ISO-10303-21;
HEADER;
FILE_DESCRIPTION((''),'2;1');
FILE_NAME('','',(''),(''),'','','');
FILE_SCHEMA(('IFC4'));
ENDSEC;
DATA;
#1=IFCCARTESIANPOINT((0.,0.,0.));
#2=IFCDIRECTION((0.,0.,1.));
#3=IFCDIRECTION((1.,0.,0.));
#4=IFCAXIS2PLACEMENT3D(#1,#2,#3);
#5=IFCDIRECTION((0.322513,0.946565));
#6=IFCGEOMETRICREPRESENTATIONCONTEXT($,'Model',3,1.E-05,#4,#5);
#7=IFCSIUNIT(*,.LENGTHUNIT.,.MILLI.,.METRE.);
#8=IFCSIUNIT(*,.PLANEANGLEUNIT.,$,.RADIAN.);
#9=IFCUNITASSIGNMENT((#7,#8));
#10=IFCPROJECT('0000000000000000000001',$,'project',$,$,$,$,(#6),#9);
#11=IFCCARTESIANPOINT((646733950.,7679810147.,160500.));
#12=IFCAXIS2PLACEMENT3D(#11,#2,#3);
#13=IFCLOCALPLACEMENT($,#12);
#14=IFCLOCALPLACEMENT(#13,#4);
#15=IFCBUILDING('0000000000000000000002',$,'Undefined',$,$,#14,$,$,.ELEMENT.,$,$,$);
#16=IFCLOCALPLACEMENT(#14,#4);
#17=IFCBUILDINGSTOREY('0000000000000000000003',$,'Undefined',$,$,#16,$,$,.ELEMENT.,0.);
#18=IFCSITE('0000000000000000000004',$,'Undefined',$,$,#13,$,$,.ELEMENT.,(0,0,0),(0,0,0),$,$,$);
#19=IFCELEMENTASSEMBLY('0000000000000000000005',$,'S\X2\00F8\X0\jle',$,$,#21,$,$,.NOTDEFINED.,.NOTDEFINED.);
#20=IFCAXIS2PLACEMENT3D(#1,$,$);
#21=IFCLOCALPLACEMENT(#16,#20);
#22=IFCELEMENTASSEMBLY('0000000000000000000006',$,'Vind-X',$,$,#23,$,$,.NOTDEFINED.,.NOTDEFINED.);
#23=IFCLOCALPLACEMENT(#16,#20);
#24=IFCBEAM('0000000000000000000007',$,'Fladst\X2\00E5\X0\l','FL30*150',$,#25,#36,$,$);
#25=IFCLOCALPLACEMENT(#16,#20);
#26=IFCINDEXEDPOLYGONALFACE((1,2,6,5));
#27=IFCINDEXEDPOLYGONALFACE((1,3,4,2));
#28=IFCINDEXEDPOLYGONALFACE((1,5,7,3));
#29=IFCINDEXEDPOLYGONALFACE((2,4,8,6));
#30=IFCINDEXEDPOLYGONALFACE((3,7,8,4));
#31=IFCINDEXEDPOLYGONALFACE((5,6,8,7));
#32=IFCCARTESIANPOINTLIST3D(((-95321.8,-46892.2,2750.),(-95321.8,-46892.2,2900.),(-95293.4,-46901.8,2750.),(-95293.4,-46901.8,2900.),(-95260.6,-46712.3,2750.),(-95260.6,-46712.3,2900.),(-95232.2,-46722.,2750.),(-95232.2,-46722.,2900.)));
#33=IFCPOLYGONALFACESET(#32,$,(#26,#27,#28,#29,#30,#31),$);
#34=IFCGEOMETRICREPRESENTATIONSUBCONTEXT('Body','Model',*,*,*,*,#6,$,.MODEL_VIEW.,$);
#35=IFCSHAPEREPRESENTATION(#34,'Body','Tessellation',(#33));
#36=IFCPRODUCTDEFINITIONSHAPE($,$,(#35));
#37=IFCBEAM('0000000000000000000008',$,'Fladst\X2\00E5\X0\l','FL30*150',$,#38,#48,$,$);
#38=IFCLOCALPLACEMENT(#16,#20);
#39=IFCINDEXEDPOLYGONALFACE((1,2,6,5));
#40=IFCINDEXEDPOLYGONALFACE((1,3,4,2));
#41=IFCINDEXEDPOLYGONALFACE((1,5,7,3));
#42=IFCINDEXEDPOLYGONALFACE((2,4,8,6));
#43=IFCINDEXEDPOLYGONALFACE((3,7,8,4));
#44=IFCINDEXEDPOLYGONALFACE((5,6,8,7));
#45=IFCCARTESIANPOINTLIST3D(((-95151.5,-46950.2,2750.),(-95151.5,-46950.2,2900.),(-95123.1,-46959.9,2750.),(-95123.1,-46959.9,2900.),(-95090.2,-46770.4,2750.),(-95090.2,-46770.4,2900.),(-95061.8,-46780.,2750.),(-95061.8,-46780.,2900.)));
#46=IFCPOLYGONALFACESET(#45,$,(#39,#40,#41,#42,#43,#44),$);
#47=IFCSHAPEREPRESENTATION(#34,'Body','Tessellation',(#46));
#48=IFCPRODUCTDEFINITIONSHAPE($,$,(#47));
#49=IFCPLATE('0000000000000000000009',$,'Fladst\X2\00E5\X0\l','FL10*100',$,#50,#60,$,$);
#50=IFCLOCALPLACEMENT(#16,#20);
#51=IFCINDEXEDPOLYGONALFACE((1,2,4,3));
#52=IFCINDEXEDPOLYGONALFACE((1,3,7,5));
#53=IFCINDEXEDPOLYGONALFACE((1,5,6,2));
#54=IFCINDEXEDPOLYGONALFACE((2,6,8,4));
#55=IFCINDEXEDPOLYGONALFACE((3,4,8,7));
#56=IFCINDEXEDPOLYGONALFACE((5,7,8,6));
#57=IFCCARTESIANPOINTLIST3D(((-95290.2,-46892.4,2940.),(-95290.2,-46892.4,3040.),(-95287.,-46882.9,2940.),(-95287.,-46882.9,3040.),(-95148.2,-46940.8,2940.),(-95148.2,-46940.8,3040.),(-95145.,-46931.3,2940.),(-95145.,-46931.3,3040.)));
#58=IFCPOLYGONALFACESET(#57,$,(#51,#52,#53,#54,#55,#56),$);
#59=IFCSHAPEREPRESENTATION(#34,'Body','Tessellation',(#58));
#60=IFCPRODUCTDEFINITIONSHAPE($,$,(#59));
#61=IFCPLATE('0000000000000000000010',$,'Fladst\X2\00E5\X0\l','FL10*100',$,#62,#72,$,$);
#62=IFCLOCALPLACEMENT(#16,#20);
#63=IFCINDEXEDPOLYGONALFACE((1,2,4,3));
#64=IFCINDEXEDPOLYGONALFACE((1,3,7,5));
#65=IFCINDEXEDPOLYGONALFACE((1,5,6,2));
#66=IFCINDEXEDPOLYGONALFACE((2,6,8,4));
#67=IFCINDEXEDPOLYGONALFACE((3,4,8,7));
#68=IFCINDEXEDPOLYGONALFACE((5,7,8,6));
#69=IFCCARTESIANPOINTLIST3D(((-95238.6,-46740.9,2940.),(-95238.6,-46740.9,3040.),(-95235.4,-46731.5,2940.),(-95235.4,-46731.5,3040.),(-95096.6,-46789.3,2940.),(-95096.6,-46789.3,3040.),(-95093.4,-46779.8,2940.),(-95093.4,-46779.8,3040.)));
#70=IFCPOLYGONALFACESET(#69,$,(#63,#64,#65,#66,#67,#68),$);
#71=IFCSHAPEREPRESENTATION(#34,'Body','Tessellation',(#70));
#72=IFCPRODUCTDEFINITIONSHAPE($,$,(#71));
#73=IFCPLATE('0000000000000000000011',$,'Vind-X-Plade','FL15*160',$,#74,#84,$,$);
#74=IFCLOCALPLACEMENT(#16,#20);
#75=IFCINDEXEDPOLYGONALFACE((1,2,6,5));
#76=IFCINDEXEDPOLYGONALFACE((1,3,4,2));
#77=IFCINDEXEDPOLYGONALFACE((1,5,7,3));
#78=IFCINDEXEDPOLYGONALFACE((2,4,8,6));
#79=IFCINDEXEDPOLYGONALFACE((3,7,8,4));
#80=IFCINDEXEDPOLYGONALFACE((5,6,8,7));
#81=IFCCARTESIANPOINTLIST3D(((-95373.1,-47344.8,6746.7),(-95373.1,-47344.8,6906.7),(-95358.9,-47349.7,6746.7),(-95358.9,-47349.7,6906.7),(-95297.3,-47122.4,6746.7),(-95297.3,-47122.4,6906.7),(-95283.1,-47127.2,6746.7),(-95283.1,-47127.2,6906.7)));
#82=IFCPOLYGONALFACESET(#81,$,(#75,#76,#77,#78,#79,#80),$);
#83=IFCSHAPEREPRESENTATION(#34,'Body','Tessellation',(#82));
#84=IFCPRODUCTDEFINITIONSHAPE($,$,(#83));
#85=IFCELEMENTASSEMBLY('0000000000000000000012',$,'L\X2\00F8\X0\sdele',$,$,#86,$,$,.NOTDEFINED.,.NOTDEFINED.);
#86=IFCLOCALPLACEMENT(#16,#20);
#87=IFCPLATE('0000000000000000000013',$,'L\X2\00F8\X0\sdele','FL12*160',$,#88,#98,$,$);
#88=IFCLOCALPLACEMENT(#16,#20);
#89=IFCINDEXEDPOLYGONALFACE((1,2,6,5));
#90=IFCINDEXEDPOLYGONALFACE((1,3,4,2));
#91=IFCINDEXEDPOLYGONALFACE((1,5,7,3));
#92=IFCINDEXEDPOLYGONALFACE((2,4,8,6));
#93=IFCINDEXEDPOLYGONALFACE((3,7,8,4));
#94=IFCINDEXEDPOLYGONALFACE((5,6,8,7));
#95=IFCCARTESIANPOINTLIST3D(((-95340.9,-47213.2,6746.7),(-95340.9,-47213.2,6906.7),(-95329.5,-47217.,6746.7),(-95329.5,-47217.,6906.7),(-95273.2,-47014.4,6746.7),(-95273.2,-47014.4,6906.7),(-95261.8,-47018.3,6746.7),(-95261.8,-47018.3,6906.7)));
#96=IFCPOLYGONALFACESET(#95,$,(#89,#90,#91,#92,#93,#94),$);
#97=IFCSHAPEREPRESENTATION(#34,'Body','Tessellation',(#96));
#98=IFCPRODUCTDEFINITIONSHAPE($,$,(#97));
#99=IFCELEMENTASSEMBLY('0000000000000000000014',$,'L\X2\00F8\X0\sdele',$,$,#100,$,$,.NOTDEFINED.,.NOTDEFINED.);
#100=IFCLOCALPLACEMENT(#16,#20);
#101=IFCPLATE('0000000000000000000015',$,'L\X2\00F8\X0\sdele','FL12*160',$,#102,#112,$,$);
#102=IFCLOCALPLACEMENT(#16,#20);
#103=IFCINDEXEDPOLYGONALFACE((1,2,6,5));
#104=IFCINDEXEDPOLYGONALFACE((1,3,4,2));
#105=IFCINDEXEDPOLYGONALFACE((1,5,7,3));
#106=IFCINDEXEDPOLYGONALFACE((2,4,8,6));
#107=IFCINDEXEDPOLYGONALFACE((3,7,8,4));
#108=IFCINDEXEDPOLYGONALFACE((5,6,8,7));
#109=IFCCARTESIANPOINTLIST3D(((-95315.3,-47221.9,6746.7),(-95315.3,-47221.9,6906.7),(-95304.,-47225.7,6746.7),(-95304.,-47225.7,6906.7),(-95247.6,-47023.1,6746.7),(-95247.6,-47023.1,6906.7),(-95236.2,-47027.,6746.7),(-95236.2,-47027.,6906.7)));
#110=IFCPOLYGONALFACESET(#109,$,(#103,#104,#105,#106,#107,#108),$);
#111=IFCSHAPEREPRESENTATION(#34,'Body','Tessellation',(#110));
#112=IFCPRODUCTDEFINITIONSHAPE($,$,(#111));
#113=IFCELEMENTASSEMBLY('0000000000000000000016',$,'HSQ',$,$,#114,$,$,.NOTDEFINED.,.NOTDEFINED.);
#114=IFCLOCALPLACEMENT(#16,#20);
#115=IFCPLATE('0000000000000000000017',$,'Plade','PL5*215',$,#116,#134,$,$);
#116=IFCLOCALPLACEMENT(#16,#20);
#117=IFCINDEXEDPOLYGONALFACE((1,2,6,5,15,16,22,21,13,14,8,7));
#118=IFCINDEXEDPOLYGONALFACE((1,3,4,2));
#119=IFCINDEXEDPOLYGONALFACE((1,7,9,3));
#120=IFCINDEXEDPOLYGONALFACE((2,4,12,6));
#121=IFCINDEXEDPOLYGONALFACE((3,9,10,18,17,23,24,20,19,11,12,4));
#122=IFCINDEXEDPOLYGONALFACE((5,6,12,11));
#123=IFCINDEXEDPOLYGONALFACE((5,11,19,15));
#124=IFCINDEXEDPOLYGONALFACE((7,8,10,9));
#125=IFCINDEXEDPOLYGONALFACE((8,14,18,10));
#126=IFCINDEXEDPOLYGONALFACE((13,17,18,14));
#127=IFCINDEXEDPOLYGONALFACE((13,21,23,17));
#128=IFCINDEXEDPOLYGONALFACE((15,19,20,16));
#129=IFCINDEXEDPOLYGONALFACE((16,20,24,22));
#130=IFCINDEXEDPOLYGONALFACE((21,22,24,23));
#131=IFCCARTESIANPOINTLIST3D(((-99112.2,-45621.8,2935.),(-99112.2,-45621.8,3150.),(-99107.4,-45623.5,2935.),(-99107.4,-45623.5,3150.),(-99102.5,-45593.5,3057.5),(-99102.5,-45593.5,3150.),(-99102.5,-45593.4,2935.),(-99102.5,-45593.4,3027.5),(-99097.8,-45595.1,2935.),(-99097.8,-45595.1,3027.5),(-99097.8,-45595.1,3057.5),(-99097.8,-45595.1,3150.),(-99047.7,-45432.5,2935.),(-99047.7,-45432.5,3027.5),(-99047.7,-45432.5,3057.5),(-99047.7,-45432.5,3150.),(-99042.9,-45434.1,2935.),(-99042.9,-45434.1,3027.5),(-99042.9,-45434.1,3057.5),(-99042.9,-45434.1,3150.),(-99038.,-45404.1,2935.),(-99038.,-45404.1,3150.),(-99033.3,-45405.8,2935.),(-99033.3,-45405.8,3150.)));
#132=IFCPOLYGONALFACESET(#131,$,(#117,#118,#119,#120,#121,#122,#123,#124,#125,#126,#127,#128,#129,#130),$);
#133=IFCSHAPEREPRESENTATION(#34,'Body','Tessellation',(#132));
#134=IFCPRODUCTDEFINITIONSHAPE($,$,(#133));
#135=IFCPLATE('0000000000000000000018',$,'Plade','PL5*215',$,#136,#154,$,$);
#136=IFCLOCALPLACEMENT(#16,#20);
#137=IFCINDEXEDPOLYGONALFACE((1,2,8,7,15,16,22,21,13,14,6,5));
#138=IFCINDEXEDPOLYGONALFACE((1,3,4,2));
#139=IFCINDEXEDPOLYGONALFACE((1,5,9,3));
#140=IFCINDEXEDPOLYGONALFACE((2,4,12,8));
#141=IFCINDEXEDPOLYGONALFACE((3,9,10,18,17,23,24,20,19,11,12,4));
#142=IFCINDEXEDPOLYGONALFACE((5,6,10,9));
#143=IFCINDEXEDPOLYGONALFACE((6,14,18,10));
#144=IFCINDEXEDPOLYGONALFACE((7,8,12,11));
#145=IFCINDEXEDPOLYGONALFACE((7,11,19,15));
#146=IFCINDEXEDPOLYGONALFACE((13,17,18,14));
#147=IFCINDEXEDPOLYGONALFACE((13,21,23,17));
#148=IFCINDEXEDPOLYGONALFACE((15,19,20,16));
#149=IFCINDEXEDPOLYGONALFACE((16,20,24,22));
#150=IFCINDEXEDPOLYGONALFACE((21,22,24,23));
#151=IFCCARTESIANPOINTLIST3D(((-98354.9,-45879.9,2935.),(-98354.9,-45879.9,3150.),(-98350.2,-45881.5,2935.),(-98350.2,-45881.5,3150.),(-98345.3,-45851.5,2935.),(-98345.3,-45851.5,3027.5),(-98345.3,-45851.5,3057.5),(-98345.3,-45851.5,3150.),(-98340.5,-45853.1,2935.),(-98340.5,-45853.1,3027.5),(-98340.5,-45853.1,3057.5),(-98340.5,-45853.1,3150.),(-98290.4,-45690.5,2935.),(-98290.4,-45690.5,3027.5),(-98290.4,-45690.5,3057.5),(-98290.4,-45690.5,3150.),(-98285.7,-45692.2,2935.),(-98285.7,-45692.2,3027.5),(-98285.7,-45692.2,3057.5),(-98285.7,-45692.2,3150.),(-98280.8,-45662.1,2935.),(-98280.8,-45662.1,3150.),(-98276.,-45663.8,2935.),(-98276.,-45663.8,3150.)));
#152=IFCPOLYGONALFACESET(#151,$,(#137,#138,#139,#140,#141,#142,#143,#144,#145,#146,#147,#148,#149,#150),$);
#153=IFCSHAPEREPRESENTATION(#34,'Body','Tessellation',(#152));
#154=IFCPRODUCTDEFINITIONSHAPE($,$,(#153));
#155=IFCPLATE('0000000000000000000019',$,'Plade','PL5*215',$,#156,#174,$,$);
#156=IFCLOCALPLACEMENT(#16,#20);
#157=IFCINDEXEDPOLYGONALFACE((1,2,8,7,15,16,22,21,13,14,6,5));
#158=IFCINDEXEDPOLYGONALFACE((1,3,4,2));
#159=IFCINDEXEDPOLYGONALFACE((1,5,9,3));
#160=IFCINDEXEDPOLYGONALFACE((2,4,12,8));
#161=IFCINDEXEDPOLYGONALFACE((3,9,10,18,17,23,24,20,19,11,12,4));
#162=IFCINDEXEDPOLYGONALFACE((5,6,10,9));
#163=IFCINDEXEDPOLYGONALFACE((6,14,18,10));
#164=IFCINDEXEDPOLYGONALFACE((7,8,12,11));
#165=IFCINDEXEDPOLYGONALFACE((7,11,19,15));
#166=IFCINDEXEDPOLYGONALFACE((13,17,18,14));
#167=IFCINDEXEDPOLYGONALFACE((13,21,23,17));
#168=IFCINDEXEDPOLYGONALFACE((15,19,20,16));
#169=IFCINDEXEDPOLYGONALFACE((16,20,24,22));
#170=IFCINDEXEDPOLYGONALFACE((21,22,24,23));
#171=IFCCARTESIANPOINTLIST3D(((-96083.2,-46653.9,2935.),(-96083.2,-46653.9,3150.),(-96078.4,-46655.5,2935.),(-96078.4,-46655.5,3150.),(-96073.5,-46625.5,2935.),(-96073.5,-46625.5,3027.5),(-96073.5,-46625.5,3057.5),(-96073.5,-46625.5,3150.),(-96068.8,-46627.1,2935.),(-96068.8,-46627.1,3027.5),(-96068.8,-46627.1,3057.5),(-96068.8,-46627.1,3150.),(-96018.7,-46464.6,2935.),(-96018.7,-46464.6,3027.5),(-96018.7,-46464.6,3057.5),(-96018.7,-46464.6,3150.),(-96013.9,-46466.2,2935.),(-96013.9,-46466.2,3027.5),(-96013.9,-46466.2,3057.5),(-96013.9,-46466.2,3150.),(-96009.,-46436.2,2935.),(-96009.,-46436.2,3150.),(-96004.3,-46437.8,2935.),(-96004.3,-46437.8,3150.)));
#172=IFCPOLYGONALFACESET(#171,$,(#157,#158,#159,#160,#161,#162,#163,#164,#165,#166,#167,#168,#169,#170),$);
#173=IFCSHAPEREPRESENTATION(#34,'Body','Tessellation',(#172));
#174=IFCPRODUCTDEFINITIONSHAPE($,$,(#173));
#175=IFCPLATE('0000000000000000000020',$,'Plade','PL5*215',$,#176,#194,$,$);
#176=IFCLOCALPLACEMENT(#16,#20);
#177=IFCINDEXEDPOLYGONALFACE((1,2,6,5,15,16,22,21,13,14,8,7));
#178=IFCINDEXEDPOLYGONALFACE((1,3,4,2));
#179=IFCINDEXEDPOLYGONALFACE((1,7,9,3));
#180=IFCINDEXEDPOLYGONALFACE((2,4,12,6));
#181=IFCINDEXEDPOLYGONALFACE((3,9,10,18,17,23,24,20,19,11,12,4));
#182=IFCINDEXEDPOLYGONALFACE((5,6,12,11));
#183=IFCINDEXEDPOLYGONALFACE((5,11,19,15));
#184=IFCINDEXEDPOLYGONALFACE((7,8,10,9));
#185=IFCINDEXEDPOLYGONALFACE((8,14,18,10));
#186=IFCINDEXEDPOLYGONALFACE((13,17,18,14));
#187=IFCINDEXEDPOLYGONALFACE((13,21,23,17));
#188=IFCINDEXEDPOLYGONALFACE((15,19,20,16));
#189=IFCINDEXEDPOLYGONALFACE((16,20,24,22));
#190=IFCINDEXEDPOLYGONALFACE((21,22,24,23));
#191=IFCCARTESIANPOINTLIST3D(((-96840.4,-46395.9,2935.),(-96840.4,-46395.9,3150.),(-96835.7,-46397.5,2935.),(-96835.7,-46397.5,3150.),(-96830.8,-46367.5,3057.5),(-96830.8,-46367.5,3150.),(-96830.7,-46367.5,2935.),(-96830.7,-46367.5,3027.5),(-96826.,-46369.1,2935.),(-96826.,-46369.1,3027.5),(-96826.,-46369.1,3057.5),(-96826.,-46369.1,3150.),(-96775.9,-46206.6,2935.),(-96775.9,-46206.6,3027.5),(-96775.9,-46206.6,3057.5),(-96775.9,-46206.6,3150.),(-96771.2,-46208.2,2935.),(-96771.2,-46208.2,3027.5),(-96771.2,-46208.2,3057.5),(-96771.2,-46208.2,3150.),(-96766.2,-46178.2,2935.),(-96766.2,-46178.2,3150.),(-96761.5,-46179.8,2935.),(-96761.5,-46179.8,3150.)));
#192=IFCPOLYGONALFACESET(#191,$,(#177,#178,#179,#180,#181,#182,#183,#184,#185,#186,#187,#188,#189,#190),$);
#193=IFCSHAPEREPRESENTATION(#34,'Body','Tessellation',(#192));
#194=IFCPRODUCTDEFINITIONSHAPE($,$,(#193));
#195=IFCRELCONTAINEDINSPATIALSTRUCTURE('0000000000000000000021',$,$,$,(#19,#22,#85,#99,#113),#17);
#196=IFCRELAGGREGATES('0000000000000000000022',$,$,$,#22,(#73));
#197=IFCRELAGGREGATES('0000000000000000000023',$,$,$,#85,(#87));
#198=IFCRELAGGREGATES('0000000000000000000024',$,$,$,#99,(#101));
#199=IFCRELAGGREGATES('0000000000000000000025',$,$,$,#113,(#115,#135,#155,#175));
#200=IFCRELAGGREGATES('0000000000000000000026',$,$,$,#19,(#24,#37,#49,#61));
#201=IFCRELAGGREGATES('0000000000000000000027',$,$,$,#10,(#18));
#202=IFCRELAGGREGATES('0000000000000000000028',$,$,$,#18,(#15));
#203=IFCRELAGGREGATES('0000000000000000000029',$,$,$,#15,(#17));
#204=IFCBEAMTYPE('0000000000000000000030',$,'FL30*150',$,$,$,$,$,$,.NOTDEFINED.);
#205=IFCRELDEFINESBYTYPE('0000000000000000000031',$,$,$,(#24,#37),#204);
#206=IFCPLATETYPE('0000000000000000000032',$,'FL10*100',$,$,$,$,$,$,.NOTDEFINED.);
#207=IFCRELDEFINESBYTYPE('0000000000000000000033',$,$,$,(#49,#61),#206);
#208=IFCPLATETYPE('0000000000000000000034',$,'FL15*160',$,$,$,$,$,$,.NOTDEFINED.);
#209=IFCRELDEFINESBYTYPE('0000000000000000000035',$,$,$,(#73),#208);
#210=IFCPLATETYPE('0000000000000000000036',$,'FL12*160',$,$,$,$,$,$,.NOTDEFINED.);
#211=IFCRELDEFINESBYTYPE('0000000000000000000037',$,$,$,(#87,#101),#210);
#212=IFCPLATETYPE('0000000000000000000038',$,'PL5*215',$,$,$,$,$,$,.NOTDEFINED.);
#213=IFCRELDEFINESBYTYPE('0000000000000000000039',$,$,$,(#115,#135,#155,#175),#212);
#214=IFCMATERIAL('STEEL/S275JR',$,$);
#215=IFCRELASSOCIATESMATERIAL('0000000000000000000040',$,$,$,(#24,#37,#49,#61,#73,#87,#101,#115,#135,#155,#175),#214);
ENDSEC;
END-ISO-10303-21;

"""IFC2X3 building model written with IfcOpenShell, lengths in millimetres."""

from ifc_helpers import new_model, si_unit, direction, frame, origin_with_axes, origin_2d_with_axis, place, context, subcontext, project, spatial, polyline, rectangle, outline, extrude, material, type_object, element, aggregate, save


model = new_model("IFC2X3")

# Units and contexts
model_context = context("Model", 3, precision=1e-05, world=origin_with_axes(), true_north=direction((0.322513, 0.946565)))
body_context = subcontext(model_context, "Body", "Model", "MODEL_VIEW")
ifc_project = project(units=[si_unit("LENGTHUNIT", "METRE", prefix="MILLI"), si_unit("PLANEANGLEUNIT", "RADIAN")], contexts=[model_context])

# Site, building, storey
site_placement = place(None, frame((646733950.0, 7679810147.0, 160500.0), z_axis=(0.0, 0.0, 1.0), x_axis=(1.0, 0.0, 0.0)))
site = spatial("IfcSite", under=ifc_project, at=site_placement, Name="Undefined", CompositionType="ELEMENT", RefLatitude=(0, 0, 0), RefLongitude=(0, 0, 0))
building_placement = place(site_placement, origin_with_axes())
building = spatial("IfcBuilding", under=site, at=building_placement, Name="Undefined", CompositionType="ELEMENT")
storey_placement = place(building_placement, origin_with_axes())
storey = spatial("IfcBuildingStorey", under=building, at=storey_placement, Name="Undefined", CompositionType="ELEMENT", Elevation=0.0)

# Element assembly
assembly_1_placement = place(storey_placement, origin_with_axes())
assembly_1 = element("IfcElementAssembly", 1, at=assembly_1_placement, inside=storey, Name="Søjle", AssemblyPlace="NOTDEFINED", PredefinedType="NOTDEFINED")

# Element assembly
assembly_2_placement = place(storey_placement, origin_with_axes())
assembly_2 = element("IfcElementAssembly", 2, at=assembly_2_placement, inside=storey, Name="Vind-X", AssemblyPlace="NOTDEFINED", PredefinedType="NOTDEFINED")

# Beams
ifc_material_1 = material(Name="STEEL/S275JR")
beam_type_1 = type_object("IfcBeamType", Name="FL30*150", PredefinedType="NOTDEFINED")
beam_1_placement = place(assembly_1_placement, frame((-95277.0, -46807.1, 2900.0), z_axis=(-0.322513, -0.946565, 0.0), x_axis=(0.0, 0.0, -1.0)))
beam_1 = element("IfcBeam", 3, at=beam_1_placement, type_object=beam_type_1, material=ifc_material_1, Name="Fladstål", Description="FL30*150", context=body_context, shape_type="SweptSolid", body=[
    extrude(rectangle(XDim=30.0, YDim=190.0, at=origin_2d_with_axis()), frame((150.0, 0.0, 0.0), z_axis=(-1.0, 0.0, 0.0), x_axis=(0.0, -1.0, 0.0)), (0.0, 0.0, 1.0), 150.0),
])
beam_2_placement = place(assembly_1_placement, frame((-95106.6, -46865.1, 2900.0), z_axis=(-0.322513, -0.946565, 0.0), x_axis=(0.0, 0.0, -1.0)))
beam_2 = element("IfcBeam", 4, at=beam_2_placement, type_object=beam_type_1, material=ifc_material_1, Name="Fladstål", Description="FL30*150", context=body_context, shape_type="SweptSolid", body=[
    extrude(rectangle(XDim=30.0, YDim=190.0, at=origin_2d_with_axis()), frame((150.0, 0.0, 0.0), z_axis=(-1.0, 0.0, 0.0), x_axis=(0.0, -1.0, 0.0)), (0.0, 0.0, 1.0), 150.0),
])

# Plates
plate_type_1 = type_object("IfcPlateType", Name="FL10*100", PredefinedType="NOTDEFINED")
plate_1_placement = place(assembly_1_placement, frame((-95146.6, -46936.0, 3040.0), z_axis=(-0.322513, -0.946565, 0.0), x_axis=(-0.946565, 0.322513, 0.0)))
plate_1 = element("IfcPlate", 5, at=plate_1_placement, type_object=plate_type_1, material=ifc_material_1, Name="Fladstål", Description="FL10*100", context=body_context, shape_type="SweptSolid", body=[
    extrude(outline(polyline([(0.0, 0.0), (150.0, 0.0), (150.0, 100.0), (0.0, 100.0), (0.0, 0.0)])), frame((0.0, 0.0, -5.0), z_axis=(0.0, 0.0, 1.0), x_axis=(1.0, 0.0, 0.0)), (0.0, 0.0, 1.0), 10.0),
])
plate_2_placement = place(assembly_1_placement, frame((-95095.0, -46784.6, 3040.0), z_axis=(-0.322513, -0.946565, 0.0), x_axis=(-0.946565, 0.322513, 0.0)))
plate_2 = element("IfcPlate", 6, at=plate_2_placement, type_object=plate_type_1, material=ifc_material_1, Name="Fladstål", Description="FL10*100", context=body_context, shape_type="SweptSolid", body=[
    extrude(outline(polyline([(0.0, 0.0), (150.0, 0.0), (150.0, 100.0), (0.0, 100.0), (0.0, 0.0)])), frame((0.0, 0.0, -5.0), z_axis=(0.0, 0.0, 1.0), x_axis=(1.0, 0.0, 0.0)), (0.0, 0.0, 1.0), 10.0),
])
plate_type_2 = type_object("IfcPlateType", Name="FL15*160", PredefinedType="NOTDEFINED")
plate_3_placement = place(assembly_2_placement, frame((-95290.2, -47124.8, 6826.7), z_axis=(0.946565, -0.322513, 0.0), x_axis=(-0.322513, -0.946565, 0.0)))
plate_3 = element("IfcPlate", 7, at=plate_3_placement, type_object=plate_type_2, material=ifc_material_1, Name="Vind-X-Plade", Description="FL15*160", context=body_context, shape_type="SweptSolid", body=[
    extrude(outline(polyline([(0.0, -80.0), (0.0, 80.0), (235.0, 80.0), (235.0, -80.0), (0.0, -80.0)])), frame((0.0, 0.0, -7.5), z_axis=(0.0, 0.0, 1.0), x_axis=(1.0, 0.0, 0.0)), (0.0, 0.0, 1.0), 15.0),
])
aggregate(assembly_2, [plate_3])

# Element assemblies, plates
assembly_3_placement = place(storey_placement, origin_with_axes())
assembly_3 = element("IfcElementAssembly", 8, at=assembly_3_placement, inside=storey, Name="Løsdele", AssemblyPlace="NOTDEFINED", PredefinedType="NOTDEFINED")
plate_type_3 = type_object("IfcPlateType", Name="FL12*160", PredefinedType="NOTDEFINED")
plate_4_placement = place(assembly_3_placement, frame((-95267.5, -47016.3, 6826.7), z_axis=(-0.946565, 0.322513, 0.0), x_axis=(-0.322513, -0.946565, 0.0)))
plate_4 = element("IfcPlate", 9, at=plate_4_placement, type_object=plate_type_3, material=ifc_material_1, Name="Løsdele", Description="FL12*160", context=body_context, shape_type="SweptSolid", body=[
    extrude(outline(polyline([(0.0, -80.0), (0.0, 80.0), (210.0, 80.0), (210.0, -80.0), (0.0, -80.0)])), frame((0.0, 0.0, -6.0), z_axis=(0.0, 0.0, 1.0), x_axis=(1.0, 0.0, 0.0)), (0.0, 0.0, 1.0), 12.0),
])
aggregate(assembly_3, [plate_4])
assembly_4_placement = place(storey_placement, origin_with_axes())
assembly_4 = element("IfcElementAssembly", 10, at=assembly_4_placement, inside=storey, Name="Løsdele", AssemblyPlace="NOTDEFINED", PredefinedType="NOTDEFINED")
plate_5_placement = place(assembly_4_placement, frame((-95241.9, -47025.0, 6826.7), z_axis=(-0.946565, 0.322513, 0.0), x_axis=(-0.322513, -0.946565, 0.0)))
plate_5 = element("IfcPlate", 11, at=plate_5_placement, type_object=plate_type_3, material=ifc_material_1, Name="Løsdele", Description="FL12*160", context=body_context, shape_type="SweptSolid", body=[
    extrude(outline(polyline([(0.0, -80.0), (0.0, 80.0), (210.0, 80.0), (210.0, -80.0), (0.0, -80.0)])), frame((0.0, 0.0, -6.0), z_axis=(0.0, 0.0, 1.0), x_axis=(1.0, 0.0, 0.0)), (0.0, 0.0, 1.0), 12.0),
])

# Element assembly, plates
assembly_5_placement = place(storey_placement, origin_with_axes())
assembly_5 = element("IfcElementAssembly", 12, at=assembly_5_placement, inside=storey, Name="HSQ", AssemblyPlace="NOTDEFINED", PredefinedType="NOTDEFINED")
plate_type_4 = type_object("IfcPlateType", Name="PL5*215", PredefinedType="NOTDEFINED")
plate_6_placement = place(assembly_5_placement, frame((-99109.8, -45622.7, 3150.0), z_axis=(0.946565, -0.322513, 0.0), x_axis=(0.0, 0.0, -1.0)))
plate_6 = element("IfcPlate", 13, at=plate_6_placement, type_object=plate_type_4, material=ifc_material_1, Name="Plade", Description="PL5*215", context=body_context, shape_type="SweptSolid", body=[
    extrude(outline(polyline([(0.0, 0.0), (215.0, 0.0), (215.0, 30.0), (122.5, 30.0), (122.5, 200.0), (215.0, 200.0), (215.0, 230.0), (0.0, 230.0), (0.0, 200.0), (92.5, 200.0), (92.5, 30.0), (0.0, 30.0), (0.0, 0.0)])), frame((0.0, 0.0, -2.5), z_axis=(0.0, 0.0, 1.0), x_axis=(1.0, 0.0, 0.0)), (0.0, 0.0, 1.0), 5.0),
])
plate_7_placement = place(assembly_5_placement, frame((-98352.6, -45880.7, 3150.0), z_axis=(0.946565, -0.322513, 0.0), x_axis=(0.0, 0.0, -1.0)))
plate_7 = element("IfcPlate", 14, at=plate_7_placement, type_object=plate_type_4, material=ifc_material_1, Name="Plade", Description="PL5*215", context=body_context, shape_type="SweptSolid", body=[
    extrude(outline(polyline([(0.0, 0.0), (215.0, 0.0), (215.0, 30.0), (122.5, 30.0), (122.5, 200.0), (215.0, 200.0), (215.0, 230.0), (0.0, 230.0), (0.0, 200.0), (92.5, 200.0), (92.5, 30.0), (0.0, 30.0), (0.0, 0.0)])), frame((0.0, 0.0, -2.5), z_axis=(0.0, 0.0, 1.0), x_axis=(1.0, 0.0, 0.0)), (0.0, 0.0, 1.0), 5.0),
])
plate_8_placement = place(assembly_5_placement, frame((-96080.8, -46654.7, 3150.0), z_axis=(0.946565, -0.322513, 0.0), x_axis=(0.0, 0.0, -1.0)))
plate_8 = element("IfcPlate", 15, at=plate_8_placement, type_object=plate_type_4, material=ifc_material_1, Name="Plade", Description="PL5*215", context=body_context, shape_type="SweptSolid", body=[
    extrude(outline(polyline([(0.0, 0.0), (215.0, 0.0), (215.0, 30.0), (122.5, 30.0), (122.5, 200.0), (215.0, 200.0), (215.0, 230.0), (0.0, 230.0), (0.0, 200.0), (92.5, 200.0), (92.5, 30.0), (0.0, 30.0), (0.0, 0.0)])), frame((0.0, 0.0, -2.5), z_axis=(0.0, 0.0, 1.0), x_axis=(1.0, 0.0, 0.0)), (0.0, 0.0, 1.0), 5.0),
])
plate_9_placement = place(assembly_5_placement, frame((-96838.1, -46396.7, 3150.0), z_axis=(0.946565, -0.322513, 0.0), x_axis=(0.0, 0.0, -1.0)))
plate_9 = element("IfcPlate", 16, at=plate_9_placement, type_object=plate_type_4, material=ifc_material_1, Name="Plade", Description="PL5*215", context=body_context, shape_type="SweptSolid", body=[
    extrude(outline(polyline([(0.0, 0.0), (215.0, 0.0), (215.0, 30.0), (122.5, 30.0), (122.5, 200.0), (215.0, 200.0), (215.0, 230.0), (0.0, 230.0), (0.0, 200.0), (92.5, 200.0), (92.5, 30.0), (0.0, 30.0), (0.0, 0.0)])), frame((0.0, 0.0, -2.5), z_axis=(0.0, 0.0, 1.0), x_axis=(1.0, 0.0, 0.0)), (0.0, 0.0, 1.0), 5.0),
])

aggregate(assembly_4, [plate_5])

aggregate(assembly_5, [plate_6, plate_7, plate_8, plate_9])
aggregate(assembly_1, [beam_1, beam_2, plate_1, plate_2])

save(model, "model.ifc")
